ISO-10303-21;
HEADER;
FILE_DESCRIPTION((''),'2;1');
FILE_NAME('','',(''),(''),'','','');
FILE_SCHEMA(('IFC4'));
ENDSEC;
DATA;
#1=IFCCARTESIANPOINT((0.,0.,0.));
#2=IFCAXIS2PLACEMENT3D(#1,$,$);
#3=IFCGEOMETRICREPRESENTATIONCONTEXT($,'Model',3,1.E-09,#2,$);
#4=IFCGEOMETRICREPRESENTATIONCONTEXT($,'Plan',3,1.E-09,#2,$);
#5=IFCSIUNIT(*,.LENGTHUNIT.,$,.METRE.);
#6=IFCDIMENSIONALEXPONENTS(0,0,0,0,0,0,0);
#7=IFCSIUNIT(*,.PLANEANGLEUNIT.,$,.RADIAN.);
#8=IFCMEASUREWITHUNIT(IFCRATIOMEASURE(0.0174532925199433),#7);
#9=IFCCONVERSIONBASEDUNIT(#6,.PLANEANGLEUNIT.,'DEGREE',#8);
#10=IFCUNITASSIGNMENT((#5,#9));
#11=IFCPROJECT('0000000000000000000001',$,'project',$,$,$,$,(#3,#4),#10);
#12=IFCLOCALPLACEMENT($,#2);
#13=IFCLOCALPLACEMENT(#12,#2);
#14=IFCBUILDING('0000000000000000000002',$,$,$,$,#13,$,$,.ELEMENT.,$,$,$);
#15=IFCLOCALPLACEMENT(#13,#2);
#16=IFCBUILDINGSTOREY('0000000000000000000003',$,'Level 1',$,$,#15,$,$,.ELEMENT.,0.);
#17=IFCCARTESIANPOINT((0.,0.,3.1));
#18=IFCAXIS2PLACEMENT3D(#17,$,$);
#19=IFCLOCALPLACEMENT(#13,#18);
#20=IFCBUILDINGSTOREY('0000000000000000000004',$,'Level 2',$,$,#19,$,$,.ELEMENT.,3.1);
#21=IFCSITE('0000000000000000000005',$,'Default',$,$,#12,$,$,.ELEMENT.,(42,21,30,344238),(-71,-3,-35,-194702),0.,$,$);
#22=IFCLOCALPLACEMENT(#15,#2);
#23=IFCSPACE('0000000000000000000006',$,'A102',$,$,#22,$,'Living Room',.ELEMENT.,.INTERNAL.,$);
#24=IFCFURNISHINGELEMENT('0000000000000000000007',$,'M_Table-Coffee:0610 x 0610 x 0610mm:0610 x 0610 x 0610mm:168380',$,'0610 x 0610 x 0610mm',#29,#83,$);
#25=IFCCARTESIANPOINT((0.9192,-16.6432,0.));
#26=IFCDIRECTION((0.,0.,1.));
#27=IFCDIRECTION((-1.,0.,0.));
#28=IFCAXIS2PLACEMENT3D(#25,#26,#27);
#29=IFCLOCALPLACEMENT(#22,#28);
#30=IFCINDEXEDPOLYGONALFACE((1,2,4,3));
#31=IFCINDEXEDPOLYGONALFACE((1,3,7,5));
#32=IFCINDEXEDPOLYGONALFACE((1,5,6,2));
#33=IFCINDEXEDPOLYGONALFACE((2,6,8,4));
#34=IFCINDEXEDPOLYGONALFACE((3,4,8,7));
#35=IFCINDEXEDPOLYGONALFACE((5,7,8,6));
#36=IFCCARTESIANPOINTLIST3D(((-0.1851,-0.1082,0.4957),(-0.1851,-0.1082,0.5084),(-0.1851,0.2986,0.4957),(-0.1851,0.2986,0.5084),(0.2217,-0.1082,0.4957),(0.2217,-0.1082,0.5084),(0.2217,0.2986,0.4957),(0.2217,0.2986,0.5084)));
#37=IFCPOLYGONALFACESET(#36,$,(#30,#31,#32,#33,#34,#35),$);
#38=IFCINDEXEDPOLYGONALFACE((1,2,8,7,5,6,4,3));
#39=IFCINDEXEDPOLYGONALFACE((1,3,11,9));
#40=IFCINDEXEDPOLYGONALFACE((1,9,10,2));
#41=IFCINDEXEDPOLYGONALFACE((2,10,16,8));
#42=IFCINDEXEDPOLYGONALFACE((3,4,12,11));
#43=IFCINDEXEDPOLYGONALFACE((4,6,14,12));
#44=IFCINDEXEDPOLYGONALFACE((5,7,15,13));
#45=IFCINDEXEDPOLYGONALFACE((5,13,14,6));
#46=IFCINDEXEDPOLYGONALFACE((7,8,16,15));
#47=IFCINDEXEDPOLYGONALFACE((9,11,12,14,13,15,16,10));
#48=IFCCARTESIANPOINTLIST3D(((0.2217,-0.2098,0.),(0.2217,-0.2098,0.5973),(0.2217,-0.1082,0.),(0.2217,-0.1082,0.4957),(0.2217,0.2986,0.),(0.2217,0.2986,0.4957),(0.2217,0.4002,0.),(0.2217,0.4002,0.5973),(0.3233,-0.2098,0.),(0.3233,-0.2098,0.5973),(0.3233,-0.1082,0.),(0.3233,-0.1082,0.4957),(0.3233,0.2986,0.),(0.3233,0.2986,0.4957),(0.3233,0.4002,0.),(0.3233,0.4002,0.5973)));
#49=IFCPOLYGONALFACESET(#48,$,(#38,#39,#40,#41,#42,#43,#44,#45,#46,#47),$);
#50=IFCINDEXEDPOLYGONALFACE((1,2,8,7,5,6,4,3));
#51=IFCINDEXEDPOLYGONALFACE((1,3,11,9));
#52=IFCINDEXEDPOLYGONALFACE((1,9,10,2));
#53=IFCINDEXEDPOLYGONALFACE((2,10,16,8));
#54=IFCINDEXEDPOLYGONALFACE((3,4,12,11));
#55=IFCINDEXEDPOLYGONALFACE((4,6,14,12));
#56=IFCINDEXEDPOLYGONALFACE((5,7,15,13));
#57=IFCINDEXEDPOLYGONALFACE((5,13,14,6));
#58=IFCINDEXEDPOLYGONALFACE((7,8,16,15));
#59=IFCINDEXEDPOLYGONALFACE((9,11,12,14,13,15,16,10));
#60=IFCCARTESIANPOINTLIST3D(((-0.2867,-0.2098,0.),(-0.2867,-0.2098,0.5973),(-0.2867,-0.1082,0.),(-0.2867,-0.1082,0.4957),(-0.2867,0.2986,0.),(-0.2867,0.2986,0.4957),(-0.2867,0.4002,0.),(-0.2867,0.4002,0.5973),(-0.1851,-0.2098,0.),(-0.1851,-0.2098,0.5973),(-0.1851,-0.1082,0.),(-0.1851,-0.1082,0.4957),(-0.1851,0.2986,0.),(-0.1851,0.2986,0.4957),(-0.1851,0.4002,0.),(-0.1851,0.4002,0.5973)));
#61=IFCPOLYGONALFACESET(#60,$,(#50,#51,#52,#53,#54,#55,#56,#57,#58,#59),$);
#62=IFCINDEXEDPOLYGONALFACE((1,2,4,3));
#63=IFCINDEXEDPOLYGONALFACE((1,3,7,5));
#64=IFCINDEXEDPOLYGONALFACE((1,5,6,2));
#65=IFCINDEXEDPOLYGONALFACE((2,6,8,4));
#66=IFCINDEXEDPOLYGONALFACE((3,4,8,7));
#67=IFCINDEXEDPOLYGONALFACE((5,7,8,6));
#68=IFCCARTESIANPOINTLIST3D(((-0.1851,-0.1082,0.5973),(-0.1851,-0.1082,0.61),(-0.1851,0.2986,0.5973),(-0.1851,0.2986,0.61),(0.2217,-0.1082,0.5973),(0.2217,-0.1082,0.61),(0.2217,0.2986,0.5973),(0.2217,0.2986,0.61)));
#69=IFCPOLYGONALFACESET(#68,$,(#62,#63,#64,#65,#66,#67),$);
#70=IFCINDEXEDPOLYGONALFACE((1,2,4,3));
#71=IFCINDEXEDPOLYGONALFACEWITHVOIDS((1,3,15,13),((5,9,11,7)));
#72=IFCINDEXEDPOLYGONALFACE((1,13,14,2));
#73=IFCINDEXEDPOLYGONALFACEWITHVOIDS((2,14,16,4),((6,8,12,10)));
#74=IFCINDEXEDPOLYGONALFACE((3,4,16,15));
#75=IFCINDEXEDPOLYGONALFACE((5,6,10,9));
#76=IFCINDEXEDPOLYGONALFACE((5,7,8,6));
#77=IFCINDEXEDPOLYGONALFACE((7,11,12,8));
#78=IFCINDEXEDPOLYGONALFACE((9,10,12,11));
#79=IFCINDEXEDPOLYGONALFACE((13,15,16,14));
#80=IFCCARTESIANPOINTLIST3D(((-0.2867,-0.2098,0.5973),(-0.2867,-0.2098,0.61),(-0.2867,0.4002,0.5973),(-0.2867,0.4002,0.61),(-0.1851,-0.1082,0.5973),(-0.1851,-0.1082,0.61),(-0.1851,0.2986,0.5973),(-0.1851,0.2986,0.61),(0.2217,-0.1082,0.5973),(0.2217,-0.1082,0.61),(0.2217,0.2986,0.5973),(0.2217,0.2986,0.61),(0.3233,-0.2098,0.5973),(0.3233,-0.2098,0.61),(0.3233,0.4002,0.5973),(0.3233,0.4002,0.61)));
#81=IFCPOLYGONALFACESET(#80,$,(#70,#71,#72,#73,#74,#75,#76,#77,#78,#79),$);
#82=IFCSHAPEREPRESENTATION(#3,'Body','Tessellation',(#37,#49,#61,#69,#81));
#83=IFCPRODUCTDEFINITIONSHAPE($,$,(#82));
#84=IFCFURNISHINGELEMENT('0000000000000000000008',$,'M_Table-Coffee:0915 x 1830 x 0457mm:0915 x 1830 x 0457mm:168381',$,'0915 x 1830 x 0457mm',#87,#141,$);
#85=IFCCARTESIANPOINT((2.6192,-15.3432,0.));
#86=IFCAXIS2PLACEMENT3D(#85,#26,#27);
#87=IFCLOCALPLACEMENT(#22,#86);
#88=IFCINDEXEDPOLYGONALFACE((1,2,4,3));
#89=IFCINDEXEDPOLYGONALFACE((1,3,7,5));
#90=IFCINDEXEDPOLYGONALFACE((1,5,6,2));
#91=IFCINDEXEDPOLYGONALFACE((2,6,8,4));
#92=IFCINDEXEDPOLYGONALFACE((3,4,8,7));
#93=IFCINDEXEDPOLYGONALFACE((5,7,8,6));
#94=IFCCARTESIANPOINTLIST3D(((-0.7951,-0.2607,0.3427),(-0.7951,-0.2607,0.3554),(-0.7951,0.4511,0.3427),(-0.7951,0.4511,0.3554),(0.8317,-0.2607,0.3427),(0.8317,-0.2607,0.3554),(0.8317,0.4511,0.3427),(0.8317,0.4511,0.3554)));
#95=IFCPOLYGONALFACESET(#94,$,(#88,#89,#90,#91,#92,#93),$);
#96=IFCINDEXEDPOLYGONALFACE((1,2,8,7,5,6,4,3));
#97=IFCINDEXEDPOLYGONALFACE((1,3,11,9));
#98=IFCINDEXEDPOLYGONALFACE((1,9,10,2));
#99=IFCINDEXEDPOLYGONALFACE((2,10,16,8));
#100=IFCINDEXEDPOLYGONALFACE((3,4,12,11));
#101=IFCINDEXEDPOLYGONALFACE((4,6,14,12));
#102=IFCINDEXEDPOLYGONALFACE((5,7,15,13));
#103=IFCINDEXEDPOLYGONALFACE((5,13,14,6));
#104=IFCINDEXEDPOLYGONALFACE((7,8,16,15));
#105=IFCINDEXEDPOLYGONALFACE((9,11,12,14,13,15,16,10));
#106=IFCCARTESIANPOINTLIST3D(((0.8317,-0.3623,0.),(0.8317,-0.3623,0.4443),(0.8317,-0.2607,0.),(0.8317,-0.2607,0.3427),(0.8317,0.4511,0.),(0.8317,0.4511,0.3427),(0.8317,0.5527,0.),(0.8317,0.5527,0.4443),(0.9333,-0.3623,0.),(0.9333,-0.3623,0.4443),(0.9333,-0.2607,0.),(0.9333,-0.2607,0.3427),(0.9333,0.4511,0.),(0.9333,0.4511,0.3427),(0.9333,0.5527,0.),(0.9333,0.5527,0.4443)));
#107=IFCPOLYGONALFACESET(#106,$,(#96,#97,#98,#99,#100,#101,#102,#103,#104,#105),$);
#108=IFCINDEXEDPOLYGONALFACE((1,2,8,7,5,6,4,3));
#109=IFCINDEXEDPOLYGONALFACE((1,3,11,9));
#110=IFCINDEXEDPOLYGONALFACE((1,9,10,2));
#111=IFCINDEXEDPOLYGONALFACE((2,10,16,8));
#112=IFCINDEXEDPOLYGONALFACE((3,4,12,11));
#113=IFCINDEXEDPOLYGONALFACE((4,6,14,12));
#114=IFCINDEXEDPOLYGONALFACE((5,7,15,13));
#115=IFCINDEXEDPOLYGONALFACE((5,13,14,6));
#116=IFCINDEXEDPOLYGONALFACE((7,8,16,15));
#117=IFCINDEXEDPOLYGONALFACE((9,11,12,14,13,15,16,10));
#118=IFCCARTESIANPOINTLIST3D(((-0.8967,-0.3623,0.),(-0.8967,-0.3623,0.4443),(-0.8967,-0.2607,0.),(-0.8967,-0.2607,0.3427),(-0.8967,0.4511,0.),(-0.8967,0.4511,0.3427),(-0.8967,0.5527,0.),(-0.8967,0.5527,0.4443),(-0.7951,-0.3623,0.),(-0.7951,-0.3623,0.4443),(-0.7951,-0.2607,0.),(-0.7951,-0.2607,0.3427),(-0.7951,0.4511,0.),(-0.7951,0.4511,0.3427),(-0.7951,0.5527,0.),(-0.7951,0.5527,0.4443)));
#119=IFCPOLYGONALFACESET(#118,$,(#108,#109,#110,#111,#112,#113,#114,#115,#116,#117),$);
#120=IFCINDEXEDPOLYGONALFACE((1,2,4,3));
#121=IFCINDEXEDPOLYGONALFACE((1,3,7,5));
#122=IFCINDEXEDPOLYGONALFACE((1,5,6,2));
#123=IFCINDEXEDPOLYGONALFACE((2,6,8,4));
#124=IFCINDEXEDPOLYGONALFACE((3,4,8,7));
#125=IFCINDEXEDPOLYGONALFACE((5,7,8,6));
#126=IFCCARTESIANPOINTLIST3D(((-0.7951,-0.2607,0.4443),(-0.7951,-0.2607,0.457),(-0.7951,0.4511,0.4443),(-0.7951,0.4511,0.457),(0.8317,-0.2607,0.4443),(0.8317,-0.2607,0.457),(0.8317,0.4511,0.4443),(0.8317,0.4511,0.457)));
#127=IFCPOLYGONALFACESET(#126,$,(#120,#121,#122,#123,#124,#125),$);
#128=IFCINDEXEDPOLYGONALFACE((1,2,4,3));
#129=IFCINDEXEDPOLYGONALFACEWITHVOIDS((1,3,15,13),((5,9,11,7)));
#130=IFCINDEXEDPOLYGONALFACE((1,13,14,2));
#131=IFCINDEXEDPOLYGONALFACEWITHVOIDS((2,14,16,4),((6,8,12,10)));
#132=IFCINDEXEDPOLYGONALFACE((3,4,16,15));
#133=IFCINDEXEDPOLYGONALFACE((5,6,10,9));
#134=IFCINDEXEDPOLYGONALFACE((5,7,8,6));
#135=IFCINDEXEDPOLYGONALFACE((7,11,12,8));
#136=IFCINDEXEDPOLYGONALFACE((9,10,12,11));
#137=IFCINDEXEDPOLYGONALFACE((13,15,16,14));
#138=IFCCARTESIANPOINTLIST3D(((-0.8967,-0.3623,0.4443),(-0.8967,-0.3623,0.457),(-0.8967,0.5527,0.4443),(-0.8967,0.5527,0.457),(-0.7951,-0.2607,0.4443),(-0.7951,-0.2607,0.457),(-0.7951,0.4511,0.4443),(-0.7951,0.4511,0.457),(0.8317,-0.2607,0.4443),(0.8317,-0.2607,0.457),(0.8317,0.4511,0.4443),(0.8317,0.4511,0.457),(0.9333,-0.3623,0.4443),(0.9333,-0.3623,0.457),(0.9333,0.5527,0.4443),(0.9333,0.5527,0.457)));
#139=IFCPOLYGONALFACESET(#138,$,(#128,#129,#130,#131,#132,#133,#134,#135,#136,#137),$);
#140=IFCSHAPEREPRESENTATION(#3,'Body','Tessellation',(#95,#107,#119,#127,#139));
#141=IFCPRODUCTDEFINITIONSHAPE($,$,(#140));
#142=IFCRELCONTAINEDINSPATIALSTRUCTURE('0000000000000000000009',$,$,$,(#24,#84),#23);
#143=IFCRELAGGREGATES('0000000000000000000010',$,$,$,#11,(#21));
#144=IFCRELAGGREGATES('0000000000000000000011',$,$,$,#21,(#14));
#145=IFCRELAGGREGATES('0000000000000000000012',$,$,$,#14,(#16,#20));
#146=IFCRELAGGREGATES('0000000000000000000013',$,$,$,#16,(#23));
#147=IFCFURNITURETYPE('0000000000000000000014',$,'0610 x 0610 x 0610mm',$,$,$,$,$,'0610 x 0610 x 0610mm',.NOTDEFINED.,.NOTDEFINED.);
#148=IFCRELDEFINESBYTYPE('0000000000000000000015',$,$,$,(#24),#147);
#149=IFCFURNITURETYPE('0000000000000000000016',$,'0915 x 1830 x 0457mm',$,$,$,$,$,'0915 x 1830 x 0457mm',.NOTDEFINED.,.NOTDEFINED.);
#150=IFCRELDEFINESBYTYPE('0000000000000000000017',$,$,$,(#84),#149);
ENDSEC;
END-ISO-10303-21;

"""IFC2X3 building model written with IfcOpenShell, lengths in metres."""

from ifc_helpers import new_model, entity, si_unit, converted_unit, frame, origin, origin_2d_with_axis, place, context, project, spatial, polyline, rectangle, outline, extrude, source, transform, mapped, type_object, type_shapes, element, save


model = new_model("IFC2X3")

# Units and contexts
model_context = context("Model", 3, precision=1e-09, world=origin())
plan_context = context("Plan", 3, precision=1e-09, world=origin())
ifc_project = project(units=[si_unit("LENGTHUNIT", "METRE"), converted_unit("PLANEANGLEUNIT", "DEGREE", entity("IfcRatioMeasure", 0.0174532925199433), si_unit("PLANEANGLEUNIT", "RADIAN"), dimensions=[0, 0, 0, 0, 0, 0, 0])], contexts=[model_context, plan_context])

# Site, building, storey
site_placement = place(None, origin())
site = spatial("IfcSite", under=ifc_project, at=site_placement, Name="Default", CompositionType="ELEMENT", RefLatitude=(42, 21, 30, 344238), RefLongitude=(-71, -3, -35, -194702), RefElevation=0.0)
building_placement = place(site_placement, origin())
building = spatial("IfcBuilding", under=site, at=building_placement, CompositionType="ELEMENT")
storey_1_placement = place(building_placement, origin())
storey_1 = spatial("IfcBuildingStorey", under=building, at=storey_1_placement, Name="Level 1", CompositionType="ELEMENT", Elevation=0.0)

# Shared definitions
storey_2_placement = place(building_placement, frame((0.0, 0.0, 3.1)))
storey_2 = spatial("IfcBuildingStorey", under=building, at=storey_2_placement, Name="Level 2", CompositionType="ELEMENT", Elevation=3.1)

# Shared definitions
placement_1 = place(storey_1_placement, origin())

# Shared definitions
space_1 = spatial("IfcSpace", under=storey_1, at=placement_1, Name="A102", LongName="Living Room", CompositionType="ELEMENT", InteriorOrExteriorSpace="INTERNAL")

# Furnishing elements
furniture_type_1 = type_object("IfcFurnitureType", Name="0610 x 0610 x 0610mm", ElementType="0610 x 0610 x 0610mm", AssemblyPlace="NOTDEFINED")
shared_shape_1 = source(origin(), model_context, "Body", "SweptSolid", [
    extrude(rectangle(XDim=0.4068, YDim=0.4068, at=origin_2d_with_axis()), frame((0.0183, 0.0952, 0.4957), z_axis=(0.0, 0.0, 1.0), x_axis=(-1.0, 0.0, 0.0)), (0.0, 0.0, 1.0), 0.0127),
    extrude(outline(polyline([(-0.2732, -0.305), (0.324, -0.305), (0.324, 0.305), (-0.2732, 0.305), (-0.2732, 0.2034), (0.2225, 0.2034), (0.2225, -0.2034), (-0.2732, -0.2034), (-0.2732, -0.305)])), frame((0.2217, 0.0952, 0.2732), z_axis=(1.0, 0.0, 0.0), x_axis=(0.0, 0.0, 1.0)), (0.0, 0.0, 1.0), 0.1016),
    extrude(outline(polyline([(-0.305, -0.3241), (0.305, -0.3241), (0.305, 0.2733), (0.2034, 0.2733), (0.2034, -0.2224), (-0.2034, -0.2224), (-0.2034, 0.2733), (-0.305, 0.2733), (-0.305, -0.3241)])), frame((-0.2867, 0.0952, 0.2733), z_axis=(1.0, 0.0, 0.0), x_axis=(0.0, -1.0, 0.0)), (0.0, 0.0, 1.0), 0.1016),
    extrude(rectangle(XDim=0.4068, YDim=0.4068, at=origin_2d_with_axis()), frame((0.0183, 0.0952, 0.5973), z_axis=(0.0, 0.0, 1.0), x_axis=(-1.0, 0.0, 0.0)), (0.0, 0.0, 1.0), 0.0127),
    extrude(outline(polyline([(-0.305, -0.305), (0.305, -0.305), (0.305, 0.305), (-0.305, 0.305), (-0.305, -0.305)]), holes=[polyline([(-0.2034, -0.2034), (-0.2034, 0.2034), (0.2034, 0.2034), (0.2034, -0.2034), (-0.2034, -0.2034)])]), frame((0.0183, 0.0952, 0.5973), z_axis=(0.0, 0.0, 1.0), x_axis=(-1.0, 0.0, 0.0)), (0.0, 0.0, 1.0), 0.0127),
])
type_shapes(furniture_type_1, [shared_shape_1])
for number, where, z_axis, x_axis, name in (
    (1, (0.9192, -16.6432, 0.0), (0.0, 0.0, 1.0), (-1.0, 0.0, 0.0), "M_Table-Coffee:0610 x 0610 x 0610mm:0610 x 0610 x 0610mm:168380"),
):
    element("IfcFurnishingElement", number, at=place(placement_1, frame(where, z_axis=z_axis, x_axis=x_axis)), inside=space_1, type_object=furniture_type_1, Name=name, ObjectType="0610 x 0610 x 0610mm", context=model_context, shape_type="MappedRepresentation", body=[
        mapped(shared_shape_1, transform((0.0, 0.0, 0.0), scale=1.0)),
    ])
furniture_type_2 = type_object("IfcFurnitureType", Name="0915 x 1830 x 0457mm", ElementType="0915 x 1830 x 0457mm", AssemblyPlace="NOTDEFINED")
shared_shape_2 = source(origin(), model_context, "Body", "SweptSolid", [
    extrude(rectangle(XDim=1.6268, YDim=0.7118, at=origin_2d_with_axis()), frame((0.0183, 0.0952, 0.3427), z_axis=(0.0, 0.0, 1.0), x_axis=(-1.0, 0.0, 0.0)), (0.0, 0.0, 1.0), 0.0127),
    extrude(outline(polyline([(-0.1967, -0.4575), (0.2475, -0.4575), (0.2475, 0.4575), (-0.1967, 0.4575), (-0.1967, 0.3559), (0.146, 0.3559), (0.146, -0.3559), (-0.1967, -0.3559), (-0.1967, -0.4575)])), frame((0.8317, 0.0952, 0.1967), z_axis=(1.0, 0.0, 0.0), x_axis=(0.0, 0.0, 1.0)), (0.0, 0.0, 1.0), 0.1016),
    extrude(outline(polyline([(-0.4575, -0.2476), (0.4575, -0.2476), (0.4575, 0.1968), (0.3559, 0.1968), (0.3559, -0.1459), (-0.3559, -0.1459), (-0.3559, 0.1968), (-0.4575, 0.1968), (-0.4575, -0.2476)])), frame((-0.8967, 0.0952, 0.1968), z_axis=(1.0, 0.0, 0.0), x_axis=(0.0, -1.0, 0.0)), (0.0, 0.0, 1.0), 0.1016),
    extrude(rectangle(XDim=1.6268, YDim=0.7118, at=origin_2d_with_axis()), frame((0.0183, 0.0952, 0.4443), z_axis=(0.0, 0.0, 1.0), x_axis=(-1.0, 0.0, 0.0)), (0.0, 0.0, 1.0), 0.0127),
    extrude(outline(polyline([(-0.915, -0.4575), (0.915, -0.4575), (0.915, 0.4575), (-0.915, 0.4575), (-0.915, -0.4575)]), holes=[polyline([(-0.8134, -0.3559), (-0.8134, 0.3559), (0.8134, 0.3559), (0.8134, -0.3559), (-0.8134, -0.3559)])]), frame((0.0183, 0.0952, 0.4443), z_axis=(0.0, 0.0, 1.0), x_axis=(-1.0, 0.0, 0.0)), (0.0, 0.0, 1.0), 0.0127),
])
type_shapes(furniture_type_2, [shared_shape_2])
furnishing_1_placement = place(placement_1, frame((2.6192, -15.3432, 0.0), z_axis=(0.0, 0.0, 1.0), x_axis=(-1.0, 0.0, 0.0)))
element("IfcFurnishingElement", 2, at=furnishing_1_placement, inside=space_1, type_object=furniture_type_2, Name="M_Table-Coffee:0915 x 1830 x 0457mm:0915 x 1830 x 0457mm:168381", ObjectType="0915 x 1830 x 0457mm", context=model_context, shape_type="MappedRepresentation", body=[
    mapped(shared_shape_2, transform((0.0, 0.0, 0.0), scale=1.0)),
])

save(model, "model.ifc")
